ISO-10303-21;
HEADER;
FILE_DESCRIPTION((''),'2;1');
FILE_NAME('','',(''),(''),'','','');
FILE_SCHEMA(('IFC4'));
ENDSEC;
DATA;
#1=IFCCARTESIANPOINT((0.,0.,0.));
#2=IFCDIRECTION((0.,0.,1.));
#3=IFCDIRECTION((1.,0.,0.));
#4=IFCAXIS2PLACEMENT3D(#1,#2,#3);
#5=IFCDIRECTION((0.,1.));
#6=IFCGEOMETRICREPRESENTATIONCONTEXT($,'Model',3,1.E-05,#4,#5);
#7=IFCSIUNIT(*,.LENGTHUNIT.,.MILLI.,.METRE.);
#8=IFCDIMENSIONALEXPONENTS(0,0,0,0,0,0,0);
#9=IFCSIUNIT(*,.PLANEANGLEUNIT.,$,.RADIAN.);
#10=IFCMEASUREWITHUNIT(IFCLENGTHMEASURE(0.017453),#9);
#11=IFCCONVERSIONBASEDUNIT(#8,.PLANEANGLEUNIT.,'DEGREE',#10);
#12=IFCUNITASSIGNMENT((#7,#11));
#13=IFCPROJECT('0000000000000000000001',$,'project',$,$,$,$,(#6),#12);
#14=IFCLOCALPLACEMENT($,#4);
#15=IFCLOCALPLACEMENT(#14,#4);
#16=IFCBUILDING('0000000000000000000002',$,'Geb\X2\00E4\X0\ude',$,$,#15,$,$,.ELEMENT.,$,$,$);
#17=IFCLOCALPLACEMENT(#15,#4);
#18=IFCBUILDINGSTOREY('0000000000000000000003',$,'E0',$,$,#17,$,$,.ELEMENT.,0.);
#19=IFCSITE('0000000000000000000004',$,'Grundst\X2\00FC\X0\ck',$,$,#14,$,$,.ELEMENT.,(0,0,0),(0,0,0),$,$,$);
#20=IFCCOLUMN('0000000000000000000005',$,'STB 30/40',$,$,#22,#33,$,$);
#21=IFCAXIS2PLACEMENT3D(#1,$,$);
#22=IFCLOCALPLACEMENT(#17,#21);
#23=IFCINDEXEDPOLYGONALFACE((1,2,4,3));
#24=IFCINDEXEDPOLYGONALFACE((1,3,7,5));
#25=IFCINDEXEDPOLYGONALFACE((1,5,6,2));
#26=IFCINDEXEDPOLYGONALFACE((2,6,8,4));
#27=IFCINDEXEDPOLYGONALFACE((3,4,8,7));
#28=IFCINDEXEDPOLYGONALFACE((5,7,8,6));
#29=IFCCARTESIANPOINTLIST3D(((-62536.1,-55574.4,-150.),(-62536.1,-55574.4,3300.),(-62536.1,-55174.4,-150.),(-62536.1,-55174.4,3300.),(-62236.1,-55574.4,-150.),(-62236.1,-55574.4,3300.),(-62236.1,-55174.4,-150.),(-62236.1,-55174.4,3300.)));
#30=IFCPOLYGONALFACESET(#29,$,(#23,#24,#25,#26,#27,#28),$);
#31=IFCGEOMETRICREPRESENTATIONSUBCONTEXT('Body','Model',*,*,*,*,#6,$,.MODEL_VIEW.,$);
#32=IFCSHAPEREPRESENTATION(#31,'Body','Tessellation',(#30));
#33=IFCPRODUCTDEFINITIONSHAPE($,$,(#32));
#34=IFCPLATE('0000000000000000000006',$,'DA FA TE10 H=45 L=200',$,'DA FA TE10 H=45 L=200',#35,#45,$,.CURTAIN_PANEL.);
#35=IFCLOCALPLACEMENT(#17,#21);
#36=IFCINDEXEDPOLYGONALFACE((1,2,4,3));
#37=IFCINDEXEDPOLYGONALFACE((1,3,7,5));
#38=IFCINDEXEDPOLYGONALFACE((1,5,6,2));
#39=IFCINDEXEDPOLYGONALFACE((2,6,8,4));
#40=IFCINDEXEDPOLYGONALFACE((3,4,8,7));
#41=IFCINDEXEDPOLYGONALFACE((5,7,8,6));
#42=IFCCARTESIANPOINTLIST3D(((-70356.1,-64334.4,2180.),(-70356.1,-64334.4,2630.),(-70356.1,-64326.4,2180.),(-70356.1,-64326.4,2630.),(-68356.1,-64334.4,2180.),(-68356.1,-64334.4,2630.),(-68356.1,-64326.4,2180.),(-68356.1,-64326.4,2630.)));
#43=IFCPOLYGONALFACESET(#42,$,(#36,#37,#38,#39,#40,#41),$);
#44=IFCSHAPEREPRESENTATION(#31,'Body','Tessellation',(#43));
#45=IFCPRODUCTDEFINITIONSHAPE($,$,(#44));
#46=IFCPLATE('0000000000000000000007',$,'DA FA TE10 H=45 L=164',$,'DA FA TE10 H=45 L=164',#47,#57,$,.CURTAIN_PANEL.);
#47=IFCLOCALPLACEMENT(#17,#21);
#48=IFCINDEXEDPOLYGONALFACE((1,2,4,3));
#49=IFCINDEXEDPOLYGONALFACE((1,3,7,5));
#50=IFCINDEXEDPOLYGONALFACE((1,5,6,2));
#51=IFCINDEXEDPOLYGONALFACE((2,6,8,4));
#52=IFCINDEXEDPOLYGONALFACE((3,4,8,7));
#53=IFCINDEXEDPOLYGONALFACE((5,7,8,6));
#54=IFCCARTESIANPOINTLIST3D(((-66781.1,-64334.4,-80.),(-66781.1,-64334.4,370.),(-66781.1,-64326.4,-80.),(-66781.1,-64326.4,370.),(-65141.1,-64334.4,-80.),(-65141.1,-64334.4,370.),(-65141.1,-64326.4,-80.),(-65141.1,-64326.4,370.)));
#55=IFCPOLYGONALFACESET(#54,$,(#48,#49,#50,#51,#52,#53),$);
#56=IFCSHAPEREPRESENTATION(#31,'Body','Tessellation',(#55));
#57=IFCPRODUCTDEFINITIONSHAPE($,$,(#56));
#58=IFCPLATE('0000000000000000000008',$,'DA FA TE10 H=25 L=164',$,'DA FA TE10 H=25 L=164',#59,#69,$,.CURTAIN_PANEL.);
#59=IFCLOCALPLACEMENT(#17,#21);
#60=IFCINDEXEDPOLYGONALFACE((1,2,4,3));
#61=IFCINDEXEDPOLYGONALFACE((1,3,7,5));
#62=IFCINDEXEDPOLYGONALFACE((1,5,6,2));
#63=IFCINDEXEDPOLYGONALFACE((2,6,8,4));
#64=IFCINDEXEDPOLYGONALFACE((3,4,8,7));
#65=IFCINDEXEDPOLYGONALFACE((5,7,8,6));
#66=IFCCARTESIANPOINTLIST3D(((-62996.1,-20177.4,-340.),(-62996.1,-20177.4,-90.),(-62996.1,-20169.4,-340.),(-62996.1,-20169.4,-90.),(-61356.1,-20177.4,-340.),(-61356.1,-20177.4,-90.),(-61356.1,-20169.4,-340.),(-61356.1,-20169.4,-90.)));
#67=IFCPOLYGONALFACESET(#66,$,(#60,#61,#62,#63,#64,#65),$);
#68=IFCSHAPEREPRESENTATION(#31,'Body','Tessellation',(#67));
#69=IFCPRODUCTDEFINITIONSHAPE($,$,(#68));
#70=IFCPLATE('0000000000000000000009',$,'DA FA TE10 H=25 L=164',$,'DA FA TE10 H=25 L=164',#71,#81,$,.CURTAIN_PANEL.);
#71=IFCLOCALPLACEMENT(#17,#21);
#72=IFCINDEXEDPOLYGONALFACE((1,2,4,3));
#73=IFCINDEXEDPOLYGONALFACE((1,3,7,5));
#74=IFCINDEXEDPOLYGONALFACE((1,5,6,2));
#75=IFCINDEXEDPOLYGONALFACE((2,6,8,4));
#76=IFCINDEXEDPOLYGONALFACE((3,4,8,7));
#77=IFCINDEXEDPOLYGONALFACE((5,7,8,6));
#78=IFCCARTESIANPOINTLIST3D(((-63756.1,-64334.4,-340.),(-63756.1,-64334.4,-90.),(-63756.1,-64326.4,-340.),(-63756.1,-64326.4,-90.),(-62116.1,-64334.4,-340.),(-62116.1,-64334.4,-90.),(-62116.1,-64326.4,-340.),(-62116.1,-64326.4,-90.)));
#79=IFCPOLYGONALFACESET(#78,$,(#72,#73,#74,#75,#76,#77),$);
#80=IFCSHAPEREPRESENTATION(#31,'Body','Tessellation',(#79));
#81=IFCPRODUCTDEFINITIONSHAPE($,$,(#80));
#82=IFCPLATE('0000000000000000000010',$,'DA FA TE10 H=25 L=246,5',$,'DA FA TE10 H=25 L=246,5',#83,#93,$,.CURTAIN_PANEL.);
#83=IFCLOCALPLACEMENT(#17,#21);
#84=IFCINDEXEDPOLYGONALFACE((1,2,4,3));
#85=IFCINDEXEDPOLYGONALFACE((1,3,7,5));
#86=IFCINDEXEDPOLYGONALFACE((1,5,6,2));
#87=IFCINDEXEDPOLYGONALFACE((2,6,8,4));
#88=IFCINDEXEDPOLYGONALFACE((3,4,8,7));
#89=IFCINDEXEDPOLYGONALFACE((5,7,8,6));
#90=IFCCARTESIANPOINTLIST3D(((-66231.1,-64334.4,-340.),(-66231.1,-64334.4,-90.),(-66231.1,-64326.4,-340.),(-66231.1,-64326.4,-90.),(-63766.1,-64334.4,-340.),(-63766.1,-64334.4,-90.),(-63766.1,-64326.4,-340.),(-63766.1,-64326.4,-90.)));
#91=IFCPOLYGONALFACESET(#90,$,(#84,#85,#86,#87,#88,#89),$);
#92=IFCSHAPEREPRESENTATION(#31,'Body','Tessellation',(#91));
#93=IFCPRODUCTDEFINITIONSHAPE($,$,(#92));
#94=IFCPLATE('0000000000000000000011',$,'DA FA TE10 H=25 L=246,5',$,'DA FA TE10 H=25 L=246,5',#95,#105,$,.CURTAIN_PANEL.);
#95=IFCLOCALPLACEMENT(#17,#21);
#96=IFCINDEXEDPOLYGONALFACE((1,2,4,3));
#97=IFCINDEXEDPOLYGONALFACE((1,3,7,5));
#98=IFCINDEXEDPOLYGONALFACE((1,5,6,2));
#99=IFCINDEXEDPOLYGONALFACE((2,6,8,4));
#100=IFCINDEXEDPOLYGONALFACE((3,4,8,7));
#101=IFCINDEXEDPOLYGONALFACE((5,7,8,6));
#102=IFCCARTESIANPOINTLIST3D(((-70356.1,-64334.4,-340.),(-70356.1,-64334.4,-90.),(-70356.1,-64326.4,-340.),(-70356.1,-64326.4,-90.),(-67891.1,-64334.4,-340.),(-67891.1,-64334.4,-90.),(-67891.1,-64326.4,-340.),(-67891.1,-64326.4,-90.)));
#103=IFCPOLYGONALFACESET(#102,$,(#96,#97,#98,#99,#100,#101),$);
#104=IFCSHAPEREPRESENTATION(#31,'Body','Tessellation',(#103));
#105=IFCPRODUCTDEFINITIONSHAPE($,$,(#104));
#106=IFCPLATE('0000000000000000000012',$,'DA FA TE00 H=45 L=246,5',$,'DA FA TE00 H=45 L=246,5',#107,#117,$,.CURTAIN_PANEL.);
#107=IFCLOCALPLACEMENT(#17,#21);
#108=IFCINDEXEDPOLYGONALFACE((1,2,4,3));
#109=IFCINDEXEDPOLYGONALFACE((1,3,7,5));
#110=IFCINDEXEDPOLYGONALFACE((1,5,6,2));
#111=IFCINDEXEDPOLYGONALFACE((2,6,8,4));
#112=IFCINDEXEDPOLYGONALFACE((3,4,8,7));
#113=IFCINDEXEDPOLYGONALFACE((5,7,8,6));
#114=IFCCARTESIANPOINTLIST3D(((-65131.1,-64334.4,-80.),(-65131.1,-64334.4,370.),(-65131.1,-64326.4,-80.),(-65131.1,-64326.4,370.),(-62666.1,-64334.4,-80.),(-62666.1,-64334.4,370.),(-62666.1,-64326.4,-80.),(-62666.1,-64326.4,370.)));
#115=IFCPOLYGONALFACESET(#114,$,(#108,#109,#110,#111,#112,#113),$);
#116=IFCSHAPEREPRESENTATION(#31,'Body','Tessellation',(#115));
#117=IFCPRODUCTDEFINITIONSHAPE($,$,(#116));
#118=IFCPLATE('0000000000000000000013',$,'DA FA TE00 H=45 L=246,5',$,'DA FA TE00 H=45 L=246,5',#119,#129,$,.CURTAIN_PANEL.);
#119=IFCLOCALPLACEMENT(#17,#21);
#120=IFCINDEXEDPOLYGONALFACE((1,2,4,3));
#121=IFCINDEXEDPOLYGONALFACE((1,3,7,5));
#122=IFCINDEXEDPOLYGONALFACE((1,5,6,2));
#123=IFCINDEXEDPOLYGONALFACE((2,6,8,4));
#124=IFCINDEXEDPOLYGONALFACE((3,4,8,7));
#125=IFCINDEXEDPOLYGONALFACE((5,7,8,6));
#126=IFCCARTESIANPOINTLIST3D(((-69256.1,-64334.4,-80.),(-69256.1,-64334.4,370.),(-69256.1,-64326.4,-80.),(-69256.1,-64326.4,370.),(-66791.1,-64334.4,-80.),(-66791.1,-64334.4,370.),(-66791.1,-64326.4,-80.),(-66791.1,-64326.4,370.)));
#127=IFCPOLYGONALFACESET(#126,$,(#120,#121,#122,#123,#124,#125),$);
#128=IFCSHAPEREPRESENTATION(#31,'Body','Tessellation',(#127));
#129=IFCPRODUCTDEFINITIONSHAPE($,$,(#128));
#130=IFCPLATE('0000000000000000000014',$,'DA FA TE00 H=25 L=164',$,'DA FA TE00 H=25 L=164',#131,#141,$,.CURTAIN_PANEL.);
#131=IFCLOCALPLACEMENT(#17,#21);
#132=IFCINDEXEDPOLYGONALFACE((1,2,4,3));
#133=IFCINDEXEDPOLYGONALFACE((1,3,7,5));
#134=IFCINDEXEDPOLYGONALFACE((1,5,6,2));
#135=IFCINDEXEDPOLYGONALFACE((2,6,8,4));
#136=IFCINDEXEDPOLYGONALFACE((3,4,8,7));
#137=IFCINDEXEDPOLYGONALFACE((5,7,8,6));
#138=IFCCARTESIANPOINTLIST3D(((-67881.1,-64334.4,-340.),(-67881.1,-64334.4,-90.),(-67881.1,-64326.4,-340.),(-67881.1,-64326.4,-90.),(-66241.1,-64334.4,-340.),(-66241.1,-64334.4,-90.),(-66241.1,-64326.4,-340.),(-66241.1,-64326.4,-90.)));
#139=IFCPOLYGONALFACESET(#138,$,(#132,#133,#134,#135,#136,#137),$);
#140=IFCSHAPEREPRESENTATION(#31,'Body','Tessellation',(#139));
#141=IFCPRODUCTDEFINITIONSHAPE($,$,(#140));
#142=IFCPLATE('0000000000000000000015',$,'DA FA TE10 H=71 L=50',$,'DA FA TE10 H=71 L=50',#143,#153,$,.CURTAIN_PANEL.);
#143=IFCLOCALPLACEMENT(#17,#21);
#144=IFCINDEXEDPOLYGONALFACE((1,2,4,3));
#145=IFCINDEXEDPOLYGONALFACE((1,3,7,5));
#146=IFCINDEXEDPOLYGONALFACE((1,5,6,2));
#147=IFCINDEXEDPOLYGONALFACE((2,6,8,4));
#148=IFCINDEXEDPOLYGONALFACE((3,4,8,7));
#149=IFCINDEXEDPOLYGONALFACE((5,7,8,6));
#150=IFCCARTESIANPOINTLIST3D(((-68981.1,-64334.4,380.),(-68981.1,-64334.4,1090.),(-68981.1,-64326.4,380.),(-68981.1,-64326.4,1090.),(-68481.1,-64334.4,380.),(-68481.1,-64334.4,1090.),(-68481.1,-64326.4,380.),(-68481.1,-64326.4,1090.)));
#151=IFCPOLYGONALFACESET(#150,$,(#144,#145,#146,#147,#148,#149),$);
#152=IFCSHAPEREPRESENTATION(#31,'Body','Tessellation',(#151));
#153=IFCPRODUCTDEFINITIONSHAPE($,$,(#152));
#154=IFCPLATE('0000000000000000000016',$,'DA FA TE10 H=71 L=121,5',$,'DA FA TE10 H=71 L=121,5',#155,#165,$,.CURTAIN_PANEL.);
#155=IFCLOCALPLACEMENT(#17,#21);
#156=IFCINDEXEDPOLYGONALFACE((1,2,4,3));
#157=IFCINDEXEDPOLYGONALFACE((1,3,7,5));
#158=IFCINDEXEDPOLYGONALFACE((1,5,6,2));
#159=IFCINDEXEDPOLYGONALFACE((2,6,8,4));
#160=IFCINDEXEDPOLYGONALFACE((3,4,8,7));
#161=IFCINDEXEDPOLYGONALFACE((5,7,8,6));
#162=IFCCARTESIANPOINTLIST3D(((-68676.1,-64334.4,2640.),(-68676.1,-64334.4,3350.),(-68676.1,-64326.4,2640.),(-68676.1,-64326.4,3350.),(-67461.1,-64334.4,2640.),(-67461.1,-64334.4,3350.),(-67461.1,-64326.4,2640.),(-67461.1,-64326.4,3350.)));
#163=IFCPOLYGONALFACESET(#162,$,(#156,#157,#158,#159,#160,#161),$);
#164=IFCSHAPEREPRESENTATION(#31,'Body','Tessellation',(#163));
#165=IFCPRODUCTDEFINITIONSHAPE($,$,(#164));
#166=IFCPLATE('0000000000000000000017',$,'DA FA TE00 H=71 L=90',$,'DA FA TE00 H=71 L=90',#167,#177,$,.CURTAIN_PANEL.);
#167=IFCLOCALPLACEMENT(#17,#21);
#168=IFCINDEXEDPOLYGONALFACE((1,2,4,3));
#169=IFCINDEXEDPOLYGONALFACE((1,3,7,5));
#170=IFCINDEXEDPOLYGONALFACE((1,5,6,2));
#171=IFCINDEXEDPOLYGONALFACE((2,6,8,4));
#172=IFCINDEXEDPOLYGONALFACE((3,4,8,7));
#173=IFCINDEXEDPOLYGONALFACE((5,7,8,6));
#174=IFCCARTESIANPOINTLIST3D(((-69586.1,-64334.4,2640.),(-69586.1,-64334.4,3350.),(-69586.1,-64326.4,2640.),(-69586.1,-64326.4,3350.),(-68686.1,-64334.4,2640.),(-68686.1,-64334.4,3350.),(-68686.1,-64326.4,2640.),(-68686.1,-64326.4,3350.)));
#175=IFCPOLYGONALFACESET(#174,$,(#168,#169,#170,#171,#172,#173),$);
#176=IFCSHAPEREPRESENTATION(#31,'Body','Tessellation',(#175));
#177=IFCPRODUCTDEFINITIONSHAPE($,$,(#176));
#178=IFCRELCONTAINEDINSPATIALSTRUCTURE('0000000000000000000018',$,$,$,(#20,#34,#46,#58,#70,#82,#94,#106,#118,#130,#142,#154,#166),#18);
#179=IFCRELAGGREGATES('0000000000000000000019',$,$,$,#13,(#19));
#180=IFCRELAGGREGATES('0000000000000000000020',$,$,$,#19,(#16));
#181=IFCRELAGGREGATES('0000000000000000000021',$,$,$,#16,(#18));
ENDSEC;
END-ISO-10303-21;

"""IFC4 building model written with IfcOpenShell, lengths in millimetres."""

from ifc_helpers import new_model, entity, si_unit, converted_unit, direction, frame, origin_with_axes, place, context, subcontext, project, spatial, line, indexed_curve, outline, extrude, source, transform, mapped, element, save


model = new_model("IFC4")

# Units and contexts
model_context = context("Model", 3, precision=1e-05, world=origin_with_axes(), true_north=direction((0.0, 1.0)))
body_context = subcontext(model_context, "Body", "Model", "MODEL_VIEW")
ifc_project = project(units=[si_unit("LENGTHUNIT", "METRE", prefix="MILLI"), converted_unit("PLANEANGLEUNIT", "DEGREE", entity("IfcLengthMeasure", 0.017453), si_unit("PLANEANGLEUNIT", "RADIAN"), dimensions=[0, 0, 0, 0, 0, 0, 0])], contexts=[model_context])

# Site, building, storey
site_placement = place(None, origin_with_axes())
site = spatial("IfcSite", under=ifc_project, at=site_placement, Name="Grundstück", CompositionType="ELEMENT", RefLatitude=(0, 0, 0), RefLongitude=(0, 0, 0))
building_placement = place(site_placement, origin_with_axes())
building = spatial("IfcBuilding", under=site, at=building_placement, Name="Gebäude", CompositionType="ELEMENT")
storey_placement = place(building_placement, origin_with_axes())
storey = spatial("IfcBuildingStorey", under=building, at=storey_placement, Name="E0", CompositionType="ELEMENT", Elevation=0.0)

# Column
column_placement = place(storey_placement, frame((-62386.1, -55374.4, -150.0), z_axis=(0.0, 0.0, 1.0), x_axis=(1.0, 0.0, 0.0)))
element("IfcColumn", 1, at=column_placement, inside=storey, Name="STB 30/40", context=body_context, shape_type="SweptSolid", body=[
    extrude(outline(indexed_curve([(-150.0, -200.0), (150.0, -200.0), (150.0, 200.0), (-150.0, 200.0)], segments=[line(1, 2), line(2, 3), line(3, 4), line(4, 1)])), origin_with_axes(), (0.0, 0.0, 1.0), 3450.0),
])

# Plates
shared_shape_1 = source(origin_with_axes(), body_context, "Body", "SweptSolid", [
    extrude(outline(indexed_curve([(-1000.0, 0.0), (1000.0, 0.0), (1000.0, 8.0), (-1000.0, 8.0)], segments=[line(1, 2), line(2, 3), line(3, 4), line(4, 1)])), frame((0.0, 0.0, 450.0), z_axis=(0.0, 0.0, 1.0), x_axis=(1.0, 0.0, 0.0)), (0.0, 0.0, -1.0), 450.0),
])
plate_1_placement = place(storey_placement, frame((-69356.1, -64334.4, 2180.0), z_axis=(0.0, 0.0, 1.0), x_axis=(1.0, 0.0, 0.0)))
element("IfcPlate", 2, at=plate_1_placement, inside=storey, Name="DA FA TE10 H=45 L=200", ObjectType="DA FA TE10 H=45 L=200", PredefinedType="CURTAIN_PANEL", context=body_context, shape_type="MappedRepresentation", body=[
    mapped(shared_shape_1, transform((0.0, 0.0, 0.0), x_axis=(1.0, 0.0, 0.0), y_axis=(0.0, 1.0, 0.0), z_axis=(0.0, 0.0, 1.0), scale=1.0)),
])
shared_shape_2 = source(origin_with_axes(), body_context, "Body", "SweptSolid", [
    extrude(outline(indexed_curve([(-820.0, 0.0), (820.0, 0.0), (820.0, 8.0), (-820.0, 8.0)], segments=[line(1, 2), line(2, 3), line(3, 4), line(4, 1)])), frame((0.0, 0.0, 450.0), z_axis=(0.0, 0.0, 1.0), x_axis=(1.0, 0.0, 0.0)), (0.0, 0.0, -1.0), 450.0),
])
plate_2_placement = place(storey_placement, frame((-65961.1, -64334.4, -80.0), z_axis=(0.0, 0.0, 1.0), x_axis=(1.0, 0.0, 0.0)))
element("IfcPlate", 3, at=plate_2_placement, inside=storey, Name="DA FA TE10 H=45 L=164", ObjectType="DA FA TE10 H=45 L=164", PredefinedType="CURTAIN_PANEL", context=body_context, shape_type="MappedRepresentation", body=[
    mapped(shared_shape_2, transform((0.0, 0.0, 0.0), x_axis=(1.0, 0.0, 0.0), y_axis=(0.0, 1.0, 0.0), z_axis=(0.0, 0.0, 1.0), scale=1.0)),
])
shared_shape_3 = source(origin_with_axes(), body_context, "Body", "SweptSolid", [
    extrude(outline(indexed_curve([(-820.0, 0.0), (820.0, 0.0), (820.0, 8.0), (-820.0, 8.0)], segments=[line(1, 2), line(2, 3), line(3, 4), line(4, 1)])), frame((0.0, 0.0, 250.0), z_axis=(0.0, 0.0, 1.0), x_axis=(1.0, 0.0, 0.0)), (0.0, 0.0, -1.0), 250.0),
])
for number, where, z_axis, x_axis, name in (
    (4, (-62176.1, -20169.4, -340.0), (0.0, 0.0, 1.0), (-1.0, 0.0, 0.0), "DA FA TE10 H=25 L=164"),
    (5, (-62936.1, -64334.4, -340.0), (0.0, 0.0, 1.0), (1.0, 0.0, 0.0), "DA FA TE10 H=25 L=164"),
):
    element("IfcPlate", number, at=place(storey_placement, frame(where, z_axis=z_axis, x_axis=x_axis)), inside=storey, Name=name, ObjectType="DA FA TE10 H=25 L=164", PredefinedType="CURTAIN_PANEL", context=body_context, shape_type="MappedRepresentation", body=[
        mapped(shared_shape_3, transform((0.0, 0.0, 0.0), x_axis=(1.0, 0.0, 0.0), y_axis=(0.0, 1.0, 0.0), z_axis=(0.0, 0.0, 1.0), scale=1.0)),
    ])
shared_shape_4 = source(origin_with_axes(), body_context, "Body", "SweptSolid", [
    extrude(outline(indexed_curve([(-1232.5, 0.0), (1232.5, 0.0), (1232.5, 8.0), (-1232.5, 8.0)], segments=[line(1, 2), line(2, 3), line(3, 4), line(4, 1)])), frame((0.0, 0.0, 250.0), z_axis=(0.0, 0.0, 1.0), x_axis=(1.0, 0.0, 0.0)), (0.0, 0.0, -1.0), 250.0),
])
for number, where, z_axis, x_axis, name in (
    (6, (-64998.6, -64334.4, -340.0), (0.0, 0.0, 1.0), (1.0, 0.0, 0.0), "DA FA TE10 H=25 L=246,5"),
    (7, (-69123.6, -64334.4, -340.0), (0.0, 0.0, 1.0), (1.0, 0.0, 0.0), "DA FA TE10 H=25 L=246,5"),
):
    element("IfcPlate", number, at=place(storey_placement, frame(where, z_axis=z_axis, x_axis=x_axis)), inside=storey, Name=name, ObjectType="DA FA TE10 H=25 L=246,5", PredefinedType="CURTAIN_PANEL", context=body_context, shape_type="MappedRepresentation", body=[
        mapped(shared_shape_4, transform((0.0, 0.0, 0.0), x_axis=(1.0, 0.0, 0.0), y_axis=(0.0, 1.0, 0.0), z_axis=(0.0, 0.0, 1.0), scale=1.0)),
    ])
shared_shape_5 = source(origin_with_axes(), body_context, "Body", "SweptSolid", [
    extrude(outline(indexed_curve([(-1232.5, 0.0), (1232.5, 0.0), (1232.5, 8.0), (-1232.5, 8.0)], segments=[line(1, 2), line(2, 3), line(3, 4), line(4, 1)])), frame((0.0, 0.0, 450.0), z_axis=(0.0, 0.0, 1.0), x_axis=(1.0, 0.0, 0.0)), (0.0, 0.0, -1.0), 450.0),
])
for number, where, z_axis, x_axis, name in (
    (8, (-63898.6, -64334.4, -80.0), (0.0, 0.0, 1.0), (1.0, 0.0, 0.0), "DA FA TE00 H=45 L=246,5"),
    (9, (-68023.6, -64334.4, -80.0), (0.0, 0.0, 1.0), (1.0, 0.0, 0.0), "DA FA TE00 H=45 L=246,5"),
):
    element("IfcPlate", number, at=place(storey_placement, frame(where, z_axis=z_axis, x_axis=x_axis)), inside=storey, Name=name, ObjectType="DA FA TE00 H=45 L=246,5", PredefinedType="CURTAIN_PANEL", context=body_context, shape_type="MappedRepresentation", body=[
        mapped(shared_shape_5, transform((0.0, 0.0, 0.0), x_axis=(1.0, 0.0, 0.0), y_axis=(0.0, 1.0, 0.0), z_axis=(0.0, 0.0, 1.0), scale=1.0)),
    ])
shared_shape_6 = source(origin_with_axes(), body_context, "Body", "SweptSolid", [
    extrude(outline(indexed_curve([(-820.0, 0.0), (820.0, 0.0), (820.0, 8.0), (-820.0, 8.0)], segments=[line(1, 2), line(2, 3), line(3, 4), line(4, 1)])), frame((0.0, 0.0, 250.0), z_axis=(0.0, 0.0, 1.0), x_axis=(1.0, 0.0, 0.0)), (0.0, 0.0, -1.0), 250.0),
])
plate_3_placement = place(storey_placement, frame((-67061.1, -64334.4, -340.0), z_axis=(0.0, 0.0, 1.0), x_axis=(1.0, 0.0, 0.0)))
element("IfcPlate", 10, at=plate_3_placement, inside=storey, Name="DA FA TE00 H=25 L=164", ObjectType="DA FA TE00 H=25 L=164", PredefinedType="CURTAIN_PANEL", context=body_context, shape_type="MappedRepresentation", body=[
    mapped(shared_shape_6, transform((0.0, 0.0, 0.0), x_axis=(1.0, 0.0, 0.0), y_axis=(0.0, 1.0, 0.0), z_axis=(0.0, 0.0, 1.0), scale=1.0)),
])
shared_shape_7 = source(origin_with_axes(), body_context, "Body", "SweptSolid", [
    extrude(outline(indexed_curve([(-250.0, 0.0), (250.0, 0.0), (250.0, 8.0), (-250.0, 8.0)], segments=[line(1, 2), line(2, 3), line(3, 4), line(4, 1)])), frame((0.0, 0.0, 710.0), z_axis=(0.0, 0.0, 1.0), x_axis=(1.0, 0.0, 0.0)), (0.0, 0.0, -1.0), 710.0),
])
plate_4_placement = place(storey_placement, frame((-68731.1, -64334.4, 380.0), z_axis=(0.0, 0.0, 1.0), x_axis=(1.0, 0.0, 0.0)))
element("IfcPlate", 11, at=plate_4_placement, inside=storey, Name="DA FA TE10 H=71 L=50", ObjectType="DA FA TE10 H=71 L=50", PredefinedType="CURTAIN_PANEL", context=body_context, shape_type="MappedRepresentation", body=[
    mapped(shared_shape_7, transform((0.0, 0.0, 0.0), x_axis=(1.0, 0.0, 0.0), y_axis=(0.0, 1.0, 0.0), z_axis=(0.0, 0.0, 1.0), scale=1.0)),
])
shared_shape_8 = source(origin_with_axes(), body_context, "Body", "SweptSolid", [
    extrude(outline(indexed_curve([(-607.5, 0.0), (607.5, 0.0), (607.5, 8.0), (-607.5, 8.0)], segments=[line(1, 2), line(2, 3), line(3, 4), line(4, 1)])), frame((0.0, 0.0, 710.0), z_axis=(0.0, 0.0, 1.0), x_axis=(1.0, 0.0, 0.0)), (0.0, 0.0, -1.0), 710.0),
])
plate_5_placement = place(storey_placement, frame((-68068.6, -64334.4, 2640.0), z_axis=(0.0, 0.0, 1.0), x_axis=(1.0, 0.0, 0.0)))
element("IfcPlate", 12, at=plate_5_placement, inside=storey, Name="DA FA TE10 H=71 L=121,5", ObjectType="DA FA TE10 H=71 L=121,5", PredefinedType="CURTAIN_PANEL", context=body_context, shape_type="MappedRepresentation", body=[
    mapped(shared_shape_8, transform((0.0, 0.0, 0.0), x_axis=(1.0, 0.0, 0.0), y_axis=(0.0, 1.0, 0.0), z_axis=(0.0, 0.0, 1.0), scale=1.0)),
])
shared_shape_9 = source(origin_with_axes(), body_context, "Body", "SweptSolid", [
    extrude(outline(indexed_curve([(-450.0, 0.0), (450.0, 0.0), (450.0, 8.0), (-450.0, 8.0)], segments=[line(1, 2), line(2, 3), line(3, 4), line(4, 1)])), frame((0.0, 0.0, 710.0), z_axis=(0.0, 0.0, 1.0), x_axis=(1.0, 0.0, 0.0)), (0.0, 0.0, -1.0), 710.0),
])
plate_6_placement = place(storey_placement, frame((-69136.1, -64334.4, 2640.0), z_axis=(0.0, 0.0, 1.0), x_axis=(1.0, 0.0, 0.0)))
element("IfcPlate", 13, at=plate_6_placement, inside=storey, Name="DA FA TE00 H=71 L=90", ObjectType="DA FA TE00 H=71 L=90", PredefinedType="CURTAIN_PANEL", context=body_context, shape_type="MappedRepresentation", body=[
    mapped(shared_shape_9, transform((0.0, 0.0, 0.0), x_axis=(1.0, 0.0, 0.0), y_axis=(0.0, 1.0, 0.0), z_axis=(0.0, 0.0, 1.0), scale=1.0)),
])

save(model, "model.ifc")
